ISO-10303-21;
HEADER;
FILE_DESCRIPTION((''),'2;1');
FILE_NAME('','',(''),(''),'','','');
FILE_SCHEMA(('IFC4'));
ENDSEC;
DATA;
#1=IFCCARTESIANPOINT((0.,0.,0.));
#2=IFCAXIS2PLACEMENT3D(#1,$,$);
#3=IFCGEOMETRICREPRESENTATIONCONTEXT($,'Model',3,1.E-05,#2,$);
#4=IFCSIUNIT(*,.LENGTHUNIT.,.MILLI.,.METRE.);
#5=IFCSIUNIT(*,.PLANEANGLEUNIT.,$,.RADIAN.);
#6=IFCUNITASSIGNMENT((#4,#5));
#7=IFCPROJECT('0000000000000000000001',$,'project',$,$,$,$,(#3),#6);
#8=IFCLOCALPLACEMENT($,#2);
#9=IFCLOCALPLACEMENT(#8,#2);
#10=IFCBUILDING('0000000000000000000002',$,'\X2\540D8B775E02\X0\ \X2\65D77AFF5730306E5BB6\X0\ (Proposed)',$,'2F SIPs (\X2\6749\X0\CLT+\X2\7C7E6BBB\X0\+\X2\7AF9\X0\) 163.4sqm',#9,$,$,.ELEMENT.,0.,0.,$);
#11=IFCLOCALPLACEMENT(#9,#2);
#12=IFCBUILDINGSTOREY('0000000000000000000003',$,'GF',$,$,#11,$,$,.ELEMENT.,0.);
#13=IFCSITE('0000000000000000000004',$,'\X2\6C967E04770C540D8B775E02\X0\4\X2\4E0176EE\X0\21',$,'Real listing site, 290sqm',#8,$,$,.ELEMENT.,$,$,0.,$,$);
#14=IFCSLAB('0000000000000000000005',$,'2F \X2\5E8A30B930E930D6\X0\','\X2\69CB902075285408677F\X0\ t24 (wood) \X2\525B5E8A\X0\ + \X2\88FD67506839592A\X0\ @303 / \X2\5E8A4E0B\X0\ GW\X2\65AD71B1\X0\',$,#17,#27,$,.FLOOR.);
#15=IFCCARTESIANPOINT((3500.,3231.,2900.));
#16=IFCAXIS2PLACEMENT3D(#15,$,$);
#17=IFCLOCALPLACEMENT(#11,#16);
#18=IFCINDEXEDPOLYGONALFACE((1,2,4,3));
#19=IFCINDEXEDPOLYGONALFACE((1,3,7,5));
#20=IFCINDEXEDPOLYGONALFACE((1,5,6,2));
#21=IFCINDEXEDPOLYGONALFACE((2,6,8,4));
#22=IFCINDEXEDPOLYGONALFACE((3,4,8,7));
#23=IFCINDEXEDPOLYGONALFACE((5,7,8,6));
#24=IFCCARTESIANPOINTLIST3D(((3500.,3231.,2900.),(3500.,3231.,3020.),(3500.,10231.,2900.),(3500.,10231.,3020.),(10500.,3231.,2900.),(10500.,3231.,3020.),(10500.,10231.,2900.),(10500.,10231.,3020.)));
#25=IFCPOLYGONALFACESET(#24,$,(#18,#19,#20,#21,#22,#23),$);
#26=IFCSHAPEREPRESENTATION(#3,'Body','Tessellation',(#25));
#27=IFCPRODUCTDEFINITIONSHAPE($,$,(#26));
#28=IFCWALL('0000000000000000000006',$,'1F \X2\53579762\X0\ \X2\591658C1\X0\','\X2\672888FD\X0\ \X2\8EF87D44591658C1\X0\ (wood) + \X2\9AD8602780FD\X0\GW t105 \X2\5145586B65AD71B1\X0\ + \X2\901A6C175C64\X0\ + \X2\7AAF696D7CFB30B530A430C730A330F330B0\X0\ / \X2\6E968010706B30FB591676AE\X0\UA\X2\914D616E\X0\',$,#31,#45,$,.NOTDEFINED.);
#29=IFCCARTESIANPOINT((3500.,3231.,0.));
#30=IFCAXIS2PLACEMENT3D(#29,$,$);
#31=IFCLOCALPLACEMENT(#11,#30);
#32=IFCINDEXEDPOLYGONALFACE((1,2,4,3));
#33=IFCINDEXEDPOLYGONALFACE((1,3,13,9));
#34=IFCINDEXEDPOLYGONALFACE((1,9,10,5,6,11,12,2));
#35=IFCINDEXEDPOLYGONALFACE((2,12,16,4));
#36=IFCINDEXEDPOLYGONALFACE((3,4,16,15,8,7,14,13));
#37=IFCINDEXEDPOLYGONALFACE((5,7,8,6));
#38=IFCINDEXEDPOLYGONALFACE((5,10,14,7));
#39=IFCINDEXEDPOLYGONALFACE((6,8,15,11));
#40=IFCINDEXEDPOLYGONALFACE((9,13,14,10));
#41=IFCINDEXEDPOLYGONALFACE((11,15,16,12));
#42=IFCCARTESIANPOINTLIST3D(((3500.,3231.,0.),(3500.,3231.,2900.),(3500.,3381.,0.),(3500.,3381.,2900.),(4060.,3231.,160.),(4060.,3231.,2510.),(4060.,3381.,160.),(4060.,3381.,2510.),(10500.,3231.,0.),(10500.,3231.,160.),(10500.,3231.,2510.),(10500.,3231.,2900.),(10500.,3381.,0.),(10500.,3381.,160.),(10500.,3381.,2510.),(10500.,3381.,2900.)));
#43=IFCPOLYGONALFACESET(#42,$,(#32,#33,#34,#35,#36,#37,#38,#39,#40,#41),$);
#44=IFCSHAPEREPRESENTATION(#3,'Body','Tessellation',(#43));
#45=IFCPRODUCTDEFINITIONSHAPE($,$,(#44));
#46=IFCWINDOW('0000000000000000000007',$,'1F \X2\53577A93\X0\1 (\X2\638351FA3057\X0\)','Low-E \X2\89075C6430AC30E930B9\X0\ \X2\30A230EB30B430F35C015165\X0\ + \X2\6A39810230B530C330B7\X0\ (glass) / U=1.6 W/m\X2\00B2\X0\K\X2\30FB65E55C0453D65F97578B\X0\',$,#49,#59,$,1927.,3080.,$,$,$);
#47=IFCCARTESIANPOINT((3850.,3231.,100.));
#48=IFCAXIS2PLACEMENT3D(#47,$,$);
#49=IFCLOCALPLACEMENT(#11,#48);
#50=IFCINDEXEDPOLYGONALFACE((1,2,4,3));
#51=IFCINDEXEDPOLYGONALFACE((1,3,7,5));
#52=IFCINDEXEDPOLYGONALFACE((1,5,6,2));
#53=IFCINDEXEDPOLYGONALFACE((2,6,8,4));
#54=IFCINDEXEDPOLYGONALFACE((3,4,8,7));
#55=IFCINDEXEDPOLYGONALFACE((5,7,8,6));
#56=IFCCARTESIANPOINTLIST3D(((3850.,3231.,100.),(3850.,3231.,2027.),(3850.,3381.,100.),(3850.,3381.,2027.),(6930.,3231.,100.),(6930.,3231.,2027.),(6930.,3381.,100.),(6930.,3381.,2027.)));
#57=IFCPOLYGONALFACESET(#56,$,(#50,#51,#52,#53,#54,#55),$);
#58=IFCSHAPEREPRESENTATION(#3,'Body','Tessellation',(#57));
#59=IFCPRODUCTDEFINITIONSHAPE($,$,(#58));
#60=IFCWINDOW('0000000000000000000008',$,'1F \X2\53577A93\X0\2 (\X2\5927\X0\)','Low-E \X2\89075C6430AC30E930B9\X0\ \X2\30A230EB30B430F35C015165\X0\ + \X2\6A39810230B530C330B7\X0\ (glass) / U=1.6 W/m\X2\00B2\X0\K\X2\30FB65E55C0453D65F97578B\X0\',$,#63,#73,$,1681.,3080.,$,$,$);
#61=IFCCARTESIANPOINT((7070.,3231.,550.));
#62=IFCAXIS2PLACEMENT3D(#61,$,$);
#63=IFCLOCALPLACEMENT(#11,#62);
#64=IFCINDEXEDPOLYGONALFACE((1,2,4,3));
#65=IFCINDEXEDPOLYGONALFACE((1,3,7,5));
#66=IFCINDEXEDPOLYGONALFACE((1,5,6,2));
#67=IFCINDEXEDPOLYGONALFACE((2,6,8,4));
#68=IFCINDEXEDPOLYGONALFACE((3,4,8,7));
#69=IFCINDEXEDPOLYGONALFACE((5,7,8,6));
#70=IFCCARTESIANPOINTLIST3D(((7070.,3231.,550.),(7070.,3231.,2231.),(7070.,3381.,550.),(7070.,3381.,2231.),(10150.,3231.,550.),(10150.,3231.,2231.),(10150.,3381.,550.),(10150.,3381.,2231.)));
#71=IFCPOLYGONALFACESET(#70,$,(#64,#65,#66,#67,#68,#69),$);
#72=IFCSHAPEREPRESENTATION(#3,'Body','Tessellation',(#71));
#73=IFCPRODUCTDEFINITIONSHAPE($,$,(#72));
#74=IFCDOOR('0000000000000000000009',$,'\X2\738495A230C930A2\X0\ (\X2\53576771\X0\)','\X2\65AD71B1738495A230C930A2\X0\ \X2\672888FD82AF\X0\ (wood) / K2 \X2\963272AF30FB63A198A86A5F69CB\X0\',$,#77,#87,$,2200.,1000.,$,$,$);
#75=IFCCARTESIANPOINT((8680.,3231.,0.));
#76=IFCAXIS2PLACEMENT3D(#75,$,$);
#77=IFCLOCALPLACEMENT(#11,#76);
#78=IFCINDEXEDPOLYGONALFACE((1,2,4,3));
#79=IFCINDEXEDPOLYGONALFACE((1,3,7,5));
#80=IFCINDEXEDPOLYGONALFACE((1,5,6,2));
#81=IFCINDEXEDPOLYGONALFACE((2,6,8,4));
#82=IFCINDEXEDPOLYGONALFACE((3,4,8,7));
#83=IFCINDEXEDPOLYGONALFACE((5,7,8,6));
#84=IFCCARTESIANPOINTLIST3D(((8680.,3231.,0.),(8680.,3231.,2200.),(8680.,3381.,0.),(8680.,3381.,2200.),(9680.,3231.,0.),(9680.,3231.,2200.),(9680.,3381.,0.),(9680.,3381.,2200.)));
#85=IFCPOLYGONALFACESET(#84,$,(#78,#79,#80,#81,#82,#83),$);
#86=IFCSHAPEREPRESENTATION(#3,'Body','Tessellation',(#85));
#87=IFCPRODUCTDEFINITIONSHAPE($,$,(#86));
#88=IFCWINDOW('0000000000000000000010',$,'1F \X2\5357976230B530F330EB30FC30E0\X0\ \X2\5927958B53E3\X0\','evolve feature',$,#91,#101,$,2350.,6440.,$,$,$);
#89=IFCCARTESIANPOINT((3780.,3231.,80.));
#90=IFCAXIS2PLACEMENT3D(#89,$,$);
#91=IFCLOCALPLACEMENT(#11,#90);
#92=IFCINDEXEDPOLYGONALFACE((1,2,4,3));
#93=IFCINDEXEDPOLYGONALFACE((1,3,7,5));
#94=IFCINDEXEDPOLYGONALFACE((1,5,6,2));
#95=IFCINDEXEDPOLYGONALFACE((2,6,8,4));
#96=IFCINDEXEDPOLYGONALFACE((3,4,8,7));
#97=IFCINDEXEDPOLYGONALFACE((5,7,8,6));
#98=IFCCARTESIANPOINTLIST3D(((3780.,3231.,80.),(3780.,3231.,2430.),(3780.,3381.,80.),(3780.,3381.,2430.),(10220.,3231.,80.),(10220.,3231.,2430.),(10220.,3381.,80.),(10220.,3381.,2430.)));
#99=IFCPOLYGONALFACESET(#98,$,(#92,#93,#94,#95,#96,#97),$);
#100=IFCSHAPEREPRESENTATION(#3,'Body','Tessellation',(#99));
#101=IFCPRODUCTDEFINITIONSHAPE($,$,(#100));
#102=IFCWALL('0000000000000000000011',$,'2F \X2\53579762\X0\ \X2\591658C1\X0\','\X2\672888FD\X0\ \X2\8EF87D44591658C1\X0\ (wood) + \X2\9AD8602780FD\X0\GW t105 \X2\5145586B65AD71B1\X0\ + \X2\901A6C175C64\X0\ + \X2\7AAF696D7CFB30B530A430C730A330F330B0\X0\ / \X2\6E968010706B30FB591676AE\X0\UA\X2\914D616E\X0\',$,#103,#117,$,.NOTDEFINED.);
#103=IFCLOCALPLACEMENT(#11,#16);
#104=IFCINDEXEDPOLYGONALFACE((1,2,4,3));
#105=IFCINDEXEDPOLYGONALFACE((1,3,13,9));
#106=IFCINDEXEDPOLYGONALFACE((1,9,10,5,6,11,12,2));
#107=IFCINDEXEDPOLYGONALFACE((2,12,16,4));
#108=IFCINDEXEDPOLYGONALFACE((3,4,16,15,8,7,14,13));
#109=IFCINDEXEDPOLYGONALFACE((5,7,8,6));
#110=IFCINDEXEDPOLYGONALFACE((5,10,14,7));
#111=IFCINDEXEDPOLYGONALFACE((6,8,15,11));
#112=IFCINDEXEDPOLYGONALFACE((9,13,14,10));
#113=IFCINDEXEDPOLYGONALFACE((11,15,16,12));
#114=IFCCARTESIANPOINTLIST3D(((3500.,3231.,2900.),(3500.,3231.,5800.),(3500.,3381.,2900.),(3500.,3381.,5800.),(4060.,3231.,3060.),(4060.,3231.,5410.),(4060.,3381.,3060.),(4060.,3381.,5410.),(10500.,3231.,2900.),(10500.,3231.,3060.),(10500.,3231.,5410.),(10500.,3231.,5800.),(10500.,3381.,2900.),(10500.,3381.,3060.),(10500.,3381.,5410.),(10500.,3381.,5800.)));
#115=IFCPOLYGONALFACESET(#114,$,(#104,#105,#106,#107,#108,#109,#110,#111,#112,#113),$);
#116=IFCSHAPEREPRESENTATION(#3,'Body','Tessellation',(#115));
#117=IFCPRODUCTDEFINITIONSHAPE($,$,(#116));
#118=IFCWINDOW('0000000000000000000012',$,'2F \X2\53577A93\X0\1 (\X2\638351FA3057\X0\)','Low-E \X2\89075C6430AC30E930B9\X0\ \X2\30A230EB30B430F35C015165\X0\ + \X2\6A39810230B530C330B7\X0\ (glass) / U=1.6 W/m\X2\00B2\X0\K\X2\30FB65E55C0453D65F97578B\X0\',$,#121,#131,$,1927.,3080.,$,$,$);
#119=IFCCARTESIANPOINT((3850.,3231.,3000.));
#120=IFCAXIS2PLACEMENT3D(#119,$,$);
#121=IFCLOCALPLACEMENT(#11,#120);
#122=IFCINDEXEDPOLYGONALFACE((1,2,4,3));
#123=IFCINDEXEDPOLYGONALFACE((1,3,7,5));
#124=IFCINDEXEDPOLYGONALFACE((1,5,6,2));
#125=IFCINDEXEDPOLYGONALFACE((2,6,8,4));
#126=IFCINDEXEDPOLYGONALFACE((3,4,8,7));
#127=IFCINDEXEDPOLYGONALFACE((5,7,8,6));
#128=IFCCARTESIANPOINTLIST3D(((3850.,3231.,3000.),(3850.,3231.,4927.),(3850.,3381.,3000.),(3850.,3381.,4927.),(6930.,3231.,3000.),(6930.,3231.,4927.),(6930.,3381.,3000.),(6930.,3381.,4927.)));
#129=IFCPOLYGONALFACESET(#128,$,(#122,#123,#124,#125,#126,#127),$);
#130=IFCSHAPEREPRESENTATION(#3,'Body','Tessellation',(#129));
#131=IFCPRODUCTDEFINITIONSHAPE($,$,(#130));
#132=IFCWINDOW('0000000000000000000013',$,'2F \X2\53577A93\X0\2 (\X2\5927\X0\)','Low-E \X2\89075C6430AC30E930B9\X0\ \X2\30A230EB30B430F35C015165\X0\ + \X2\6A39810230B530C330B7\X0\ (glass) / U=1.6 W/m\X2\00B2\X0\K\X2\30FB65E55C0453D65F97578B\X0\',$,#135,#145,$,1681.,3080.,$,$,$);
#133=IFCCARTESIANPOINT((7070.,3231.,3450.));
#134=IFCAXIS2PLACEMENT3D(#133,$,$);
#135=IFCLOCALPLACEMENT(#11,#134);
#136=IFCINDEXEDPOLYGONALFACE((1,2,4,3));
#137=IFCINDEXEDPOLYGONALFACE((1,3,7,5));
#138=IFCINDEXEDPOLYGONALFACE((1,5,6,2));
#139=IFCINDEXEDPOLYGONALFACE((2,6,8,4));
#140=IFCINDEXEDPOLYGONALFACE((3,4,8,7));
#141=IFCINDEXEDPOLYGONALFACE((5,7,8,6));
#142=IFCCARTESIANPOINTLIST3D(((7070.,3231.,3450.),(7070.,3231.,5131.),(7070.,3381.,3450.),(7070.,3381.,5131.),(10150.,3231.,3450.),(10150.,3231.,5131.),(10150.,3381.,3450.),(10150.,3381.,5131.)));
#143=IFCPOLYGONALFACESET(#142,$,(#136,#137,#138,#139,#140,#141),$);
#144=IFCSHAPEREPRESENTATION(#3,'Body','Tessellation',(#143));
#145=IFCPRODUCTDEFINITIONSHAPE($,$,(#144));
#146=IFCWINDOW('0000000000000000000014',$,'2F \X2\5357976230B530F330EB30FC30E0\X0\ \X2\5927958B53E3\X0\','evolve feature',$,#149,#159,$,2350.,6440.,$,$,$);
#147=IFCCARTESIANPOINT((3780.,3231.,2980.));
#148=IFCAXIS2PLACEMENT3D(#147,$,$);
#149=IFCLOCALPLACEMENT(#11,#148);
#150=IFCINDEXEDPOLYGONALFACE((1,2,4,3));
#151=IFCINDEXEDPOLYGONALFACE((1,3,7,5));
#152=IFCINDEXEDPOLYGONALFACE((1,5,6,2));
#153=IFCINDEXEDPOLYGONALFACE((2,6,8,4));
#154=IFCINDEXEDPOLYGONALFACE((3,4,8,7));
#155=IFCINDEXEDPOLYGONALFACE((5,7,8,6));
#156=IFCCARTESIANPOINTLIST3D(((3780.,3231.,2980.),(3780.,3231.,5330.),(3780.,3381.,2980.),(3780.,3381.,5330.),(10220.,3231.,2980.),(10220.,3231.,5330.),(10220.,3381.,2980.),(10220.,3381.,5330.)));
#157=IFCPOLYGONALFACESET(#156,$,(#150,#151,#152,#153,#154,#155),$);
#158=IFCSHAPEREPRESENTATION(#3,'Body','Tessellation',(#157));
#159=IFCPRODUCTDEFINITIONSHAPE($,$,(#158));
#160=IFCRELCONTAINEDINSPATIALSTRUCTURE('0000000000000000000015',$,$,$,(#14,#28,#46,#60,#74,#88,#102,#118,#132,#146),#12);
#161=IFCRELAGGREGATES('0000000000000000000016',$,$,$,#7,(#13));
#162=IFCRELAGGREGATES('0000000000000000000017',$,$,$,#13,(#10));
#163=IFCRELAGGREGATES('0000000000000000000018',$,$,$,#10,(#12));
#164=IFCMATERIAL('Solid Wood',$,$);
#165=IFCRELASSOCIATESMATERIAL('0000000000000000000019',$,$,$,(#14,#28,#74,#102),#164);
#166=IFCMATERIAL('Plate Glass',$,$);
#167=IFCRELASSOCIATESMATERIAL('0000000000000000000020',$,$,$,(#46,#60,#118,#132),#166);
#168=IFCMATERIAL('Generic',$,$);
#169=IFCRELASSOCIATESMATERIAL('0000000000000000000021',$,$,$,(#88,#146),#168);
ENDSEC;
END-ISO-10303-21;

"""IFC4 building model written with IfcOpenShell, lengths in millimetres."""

from ifc_helpers import new_model, si_unit, frame, frame_2d, origin, place, context, project, spatial, rectangle, extrude, material, element, fill, save


model = new_model("IFC4")

# Units and contexts
model_context = context("Model", 3, precision=1e-05, world=origin())
ifc_project = project(units=[si_unit("LENGTHUNIT", "METRE", prefix="MILLI"), si_unit("PLANEANGLEUNIT", "RADIAN")], contexts=[model_context])

# Site, building, storey
site_placement = place(None, origin())
site = spatial("IfcSite", under=ifc_project, at=site_placement, Name="沖縄県名護市4丁目21", ObjectType="Real listing site, 290sqm", CompositionType="ELEMENT", RefElevation=0.0)
building_placement = place(site_placement, origin())
building = spatial("IfcBuilding", under=site, at=building_placement, Name="名護市 旗竿地の家 (Proposed)", ObjectType="2F SIPs (杉CLT+籾殻+竹) 163.4sqm", CompositionType="ELEMENT", ElevationOfRefHeight=0.0, ElevationOfTerrain=0.0)
storey_placement = place(building_placement, origin())
storey = spatial("IfcBuildingStorey", under=building, at=storey_placement, Name="GF", CompositionType="ELEMENT", Elevation=0.0)

# Slab
ifc_material_1 = material(Name="Solid Wood")
slab_1_placement = place(storey_placement, frame((3500.0, 3231.0, 2900.0)))
element("IfcSlab", 1, at=slab_1_placement, inside=storey, material=ifc_material_1, Name="2F 床スラブ", Description="構造用合板 t24 (wood) 剛床 + 製材根太 @303 / 床下 GW断熱", PredefinedType="FLOOR", context=model_context, shape_type="SweptSolid", body=[
    extrude(rectangle(XDim=7000.0, YDim=7000.0, at=frame_2d((3500.0, 3500.0))), frame((3500.0, 3231.0, 2900.0)), (0.0, 0.0, 1.0), 120.0),
])
ifc_material_2 = material(Name="Generic")

# Wall, openings, windows, door
wall_1_placement = place(storey_placement, frame((3500.0, 3231.0, 0.0)))
wall_1 = element("IfcWall", 2, at=wall_1_placement, inside=storey, material=ifc_material_1, Name="1F 南面 外壁", Description="木製 軸組外壁 (wood) + 高性能GW t105 充填断熱 + 通気層 + 窯業系サイディング / 準耐火・外皮UA配慮", PredefinedType="NOTDEFINED", context=model_context, shape_type="SweptSolid", body=[
    extrude(rectangle(XDim=7000.0, YDim=150.0, at=frame_2d((3500.0, 75.0))), frame((3500.0, 3231.0, 0.0)), (0.0, 0.0, 1.0), 2900.0),
])
opening_1_placement = place(storey_placement, frame((3850.0, 3231.0, 100.0)))
opening_1 = element("IfcOpeningElement", 3, at=opening_1_placement, cuts=wall_1, PredefinedType="NOTDEFINED", context=model_context, shape_type="SweptSolid", body=[
    extrude(rectangle(XDim=3080.0, YDim=150.0, at=frame_2d((1540.0, 75.0))), frame((3850.0, 3231.0, 100.0)), (0.0, 0.0, 1.0), 1927.0),
])
opening_2_placement = place(storey_placement, frame((7070.0, 3231.0, 550.0)))
opening_2 = element("IfcOpeningElement", 4, at=opening_2_placement, cuts=wall_1, PredefinedType="NOTDEFINED", context=model_context, shape_type="SweptSolid", body=[
    extrude(rectangle(XDim=3080.0, YDim=150.0, at=frame_2d((1540.0, 75.0))), frame((7070.0, 3231.0, 550.0)), (0.0, 0.0, 1.0), 1681.0),
])
opening_3_placement = place(storey_placement, frame((8680.0, 3231.0, 0.0)))
opening_3 = element("IfcOpeningElement", 5, at=opening_3_placement, cuts=wall_1, PredefinedType="NOTDEFINED", context=model_context, shape_type="SweptSolid", body=[
    extrude(rectangle(XDim=1000.0, YDim=150.0, at=frame_2d((500.0, 75.0))), frame((8680.0, 3231.0, 0.0)), (0.0, 0.0, 1.0), 2200.0),
])
opening_4_placement = place(storey_placement, frame((3780.0, 3231.0, 80.0)))
opening_4 = element("IfcOpeningElement", 6, at=opening_4_placement, cuts=wall_1, PredefinedType="NOTDEFINED", context=model_context, shape_type="SweptSolid", body=[
    extrude(rectangle(XDim=6440.0, YDim=150.0, at=frame_2d((3220.0, 75.0))), frame((3780.0, 3231.0, 80.0)), (0.0, 0.0, 1.0), 2350.0),
])
ifc_material_3 = material(Name="Plate Glass")
window_1_placement = place(storey_placement, frame((3850.0, 3231.0, 100.0)))
window_1 = element("IfcWindow", 7, at=window_1_placement, inside=storey, material=ifc_material_3, Name="1F 南窓1 (掃出し)", Description="Low-E 複層ガラス アルゴン封入 + 樹脂サッシ (glass) / U=1.6 W/m²K・日射取得型", OverallHeight=1927.0, OverallWidth=3080.0, context=model_context, shape_type="SweptSolid", body=[
    extrude(rectangle(XDim=3080.0, YDim=150.0, at=frame_2d((1540.0, 75.0))), frame((3850.0, 3231.0, 100.0)), (0.0, 0.0, 1.0), 1927.0),
])
fill(opening_1, window_1)
window_2_placement = place(storey_placement, frame((7070.0, 3231.0, 550.0)))
window_2 = element("IfcWindow", 8, at=window_2_placement, inside=storey, material=ifc_material_3, Name="1F 南窓2 (大)", Description="Low-E 複層ガラス アルゴン封入 + 樹脂サッシ (glass) / U=1.6 W/m²K・日射取得型", OverallHeight=1681.0, OverallWidth=3080.0, context=model_context, shape_type="SweptSolid", body=[
    extrude(rectangle(XDim=3080.0, YDim=150.0, at=frame_2d((1540.0, 75.0))), frame((7070.0, 3231.0, 550.0)), (0.0, 0.0, 1.0), 1681.0),
])
fill(opening_2, window_2)
door_placement = place(storey_placement, frame((8680.0, 3231.0, 0.0)))
door = element("IfcDoor", 9, at=door_placement, inside=storey, material=ifc_material_1, Name="玄関ドア (南東)", Description="断熱玄関ドア 木製芯 (wood) / K2 防犯・採風機構", OverallHeight=2200.0, OverallWidth=1000.0, context=model_context, shape_type="SweptSolid", body=[
    extrude(rectangle(XDim=1000.0, YDim=150.0, at=frame_2d((500.0, 75.0))), frame((8680.0, 3231.0, 0.0)), (0.0, 0.0, 1.0), 2200.0),
])
fill(opening_3, door)
window_3_placement = place(storey_placement, frame((3780.0, 3231.0, 80.0)))
window_3 = element("IfcWindow", 10, at=window_3_placement, inside=storey, material=ifc_material_2, Name="1F 南面サンルーム 大開口", Description="evolve feature", OverallHeight=2350.0, OverallWidth=6440.0, context=model_context, shape_type="SweptSolid", body=[
    extrude(rectangle(XDim=6440.0, YDim=150.0, at=frame_2d((3220.0, 75.0))), frame((3780.0, 3231.0, 80.0)), (0.0, 0.0, 1.0), 2350.0),
])
fill(opening_4, window_3)

# Wall, openings, windows
wall_2_placement = place(storey_placement, frame((3500.0, 3231.0, 2900.0)))
wall_2 = element("IfcWall", 11, at=wall_2_placement, inside=storey, material=ifc_material_1, Name="2F 南面 外壁", Description="木製 軸組外壁 (wood) + 高性能GW t105 充填断熱 + 通気層 + 窯業系サイディング / 準耐火・外皮UA配慮", PredefinedType="NOTDEFINED", context=model_context, shape_type="SweptSolid", body=[
    extrude(rectangle(XDim=7000.0, YDim=150.0, at=frame_2d((3500.0, 75.0))), frame((3500.0, 3231.0, 2900.0)), (0.0, 0.0, 1.0), 2900.0),
])
opening_5_placement = place(storey_placement, frame((3850.0, 3231.0, 3000.0)))
opening_5 = element("IfcOpeningElement", 12, at=opening_5_placement, cuts=wall_2, PredefinedType="NOTDEFINED", context=model_context, shape_type="SweptSolid", body=[
    extrude(rectangle(XDim=3080.0, YDim=150.0, at=frame_2d((1540.0, 75.0))), frame((3850.0, 3231.0, 3000.0)), (0.0, 0.0, 1.0), 1927.0),
])
opening_6_placement = place(storey_placement, frame((7070.0, 3231.0, 3450.0)))
opening_6 = element("IfcOpeningElement", 13, at=opening_6_placement, cuts=wall_2, PredefinedType="NOTDEFINED", context=model_context, shape_type="SweptSolid", body=[
    extrude(rectangle(XDim=3080.0, YDim=150.0, at=frame_2d((1540.0, 75.0))), frame((7070.0, 3231.0, 3450.0)), (0.0, 0.0, 1.0), 1681.0),
])
opening_7_placement = place(storey_placement, frame((3780.0, 3231.0, 2980.0)))
opening_7 = element("IfcOpeningElement", 14, at=opening_7_placement, cuts=wall_2, PredefinedType="NOTDEFINED", context=model_context, shape_type="SweptSolid", body=[
    extrude(rectangle(XDim=6440.0, YDim=150.0, at=frame_2d((3220.0, 75.0))), frame((3780.0, 3231.0, 2980.0)), (0.0, 0.0, 1.0), 2350.0),
])
window_4_placement = place(storey_placement, frame((3850.0, 3231.0, 3000.0)))
window_4 = element("IfcWindow", 15, at=window_4_placement, inside=storey, material=ifc_material_3, Name="2F 南窓1 (掃出し)", Description="Low-E 複層ガラス アルゴン封入 + 樹脂サッシ (glass) / U=1.6 W/m²K・日射取得型", OverallHeight=1927.0, OverallWidth=3080.0, context=model_context, shape_type="SweptSolid", body=[
    extrude(rectangle(XDim=3080.0, YDim=150.0, at=frame_2d((1540.0, 75.0))), frame((3850.0, 3231.0, 3000.0)), (0.0, 0.0, 1.0), 1927.0),
])
fill(opening_5, window_4)
window_5_placement = place(storey_placement, frame((7070.0, 3231.0, 3450.0)))
window_5 = element("IfcWindow", 16, at=window_5_placement, inside=storey, material=ifc_material_3, Name="2F 南窓2 (大)", Description="Low-E 複層ガラス アルゴン封入 + 樹脂サッシ (glass) / U=1.6 W/m²K・日射取得型", OverallHeight=1681.0, OverallWidth=3080.0, context=model_context, shape_type="SweptSolid", body=[
    extrude(rectangle(XDim=3080.0, YDim=150.0, at=frame_2d((1540.0, 75.0))), frame((7070.0, 3231.0, 3450.0)), (0.0, 0.0, 1.0), 1681.0),
])
fill(opening_6, window_5)
window_6_placement = place(storey_placement, frame((3780.0, 3231.0, 2980.0)))
window_6 = element("IfcWindow", 17, at=window_6_placement, inside=storey, material=ifc_material_2, Name="2F 南面サンルーム 大開口", Description="evolve feature", OverallHeight=2350.0, OverallWidth=6440.0, context=model_context, shape_type="SweptSolid", body=[
    extrude(rectangle(XDim=6440.0, YDim=150.0, at=frame_2d((3220.0, 75.0))), frame((3780.0, 3231.0, 2980.0)), (0.0, 0.0, 1.0), 2350.0),
])
fill(opening_7, window_6)

save(model, "model.ifc")
